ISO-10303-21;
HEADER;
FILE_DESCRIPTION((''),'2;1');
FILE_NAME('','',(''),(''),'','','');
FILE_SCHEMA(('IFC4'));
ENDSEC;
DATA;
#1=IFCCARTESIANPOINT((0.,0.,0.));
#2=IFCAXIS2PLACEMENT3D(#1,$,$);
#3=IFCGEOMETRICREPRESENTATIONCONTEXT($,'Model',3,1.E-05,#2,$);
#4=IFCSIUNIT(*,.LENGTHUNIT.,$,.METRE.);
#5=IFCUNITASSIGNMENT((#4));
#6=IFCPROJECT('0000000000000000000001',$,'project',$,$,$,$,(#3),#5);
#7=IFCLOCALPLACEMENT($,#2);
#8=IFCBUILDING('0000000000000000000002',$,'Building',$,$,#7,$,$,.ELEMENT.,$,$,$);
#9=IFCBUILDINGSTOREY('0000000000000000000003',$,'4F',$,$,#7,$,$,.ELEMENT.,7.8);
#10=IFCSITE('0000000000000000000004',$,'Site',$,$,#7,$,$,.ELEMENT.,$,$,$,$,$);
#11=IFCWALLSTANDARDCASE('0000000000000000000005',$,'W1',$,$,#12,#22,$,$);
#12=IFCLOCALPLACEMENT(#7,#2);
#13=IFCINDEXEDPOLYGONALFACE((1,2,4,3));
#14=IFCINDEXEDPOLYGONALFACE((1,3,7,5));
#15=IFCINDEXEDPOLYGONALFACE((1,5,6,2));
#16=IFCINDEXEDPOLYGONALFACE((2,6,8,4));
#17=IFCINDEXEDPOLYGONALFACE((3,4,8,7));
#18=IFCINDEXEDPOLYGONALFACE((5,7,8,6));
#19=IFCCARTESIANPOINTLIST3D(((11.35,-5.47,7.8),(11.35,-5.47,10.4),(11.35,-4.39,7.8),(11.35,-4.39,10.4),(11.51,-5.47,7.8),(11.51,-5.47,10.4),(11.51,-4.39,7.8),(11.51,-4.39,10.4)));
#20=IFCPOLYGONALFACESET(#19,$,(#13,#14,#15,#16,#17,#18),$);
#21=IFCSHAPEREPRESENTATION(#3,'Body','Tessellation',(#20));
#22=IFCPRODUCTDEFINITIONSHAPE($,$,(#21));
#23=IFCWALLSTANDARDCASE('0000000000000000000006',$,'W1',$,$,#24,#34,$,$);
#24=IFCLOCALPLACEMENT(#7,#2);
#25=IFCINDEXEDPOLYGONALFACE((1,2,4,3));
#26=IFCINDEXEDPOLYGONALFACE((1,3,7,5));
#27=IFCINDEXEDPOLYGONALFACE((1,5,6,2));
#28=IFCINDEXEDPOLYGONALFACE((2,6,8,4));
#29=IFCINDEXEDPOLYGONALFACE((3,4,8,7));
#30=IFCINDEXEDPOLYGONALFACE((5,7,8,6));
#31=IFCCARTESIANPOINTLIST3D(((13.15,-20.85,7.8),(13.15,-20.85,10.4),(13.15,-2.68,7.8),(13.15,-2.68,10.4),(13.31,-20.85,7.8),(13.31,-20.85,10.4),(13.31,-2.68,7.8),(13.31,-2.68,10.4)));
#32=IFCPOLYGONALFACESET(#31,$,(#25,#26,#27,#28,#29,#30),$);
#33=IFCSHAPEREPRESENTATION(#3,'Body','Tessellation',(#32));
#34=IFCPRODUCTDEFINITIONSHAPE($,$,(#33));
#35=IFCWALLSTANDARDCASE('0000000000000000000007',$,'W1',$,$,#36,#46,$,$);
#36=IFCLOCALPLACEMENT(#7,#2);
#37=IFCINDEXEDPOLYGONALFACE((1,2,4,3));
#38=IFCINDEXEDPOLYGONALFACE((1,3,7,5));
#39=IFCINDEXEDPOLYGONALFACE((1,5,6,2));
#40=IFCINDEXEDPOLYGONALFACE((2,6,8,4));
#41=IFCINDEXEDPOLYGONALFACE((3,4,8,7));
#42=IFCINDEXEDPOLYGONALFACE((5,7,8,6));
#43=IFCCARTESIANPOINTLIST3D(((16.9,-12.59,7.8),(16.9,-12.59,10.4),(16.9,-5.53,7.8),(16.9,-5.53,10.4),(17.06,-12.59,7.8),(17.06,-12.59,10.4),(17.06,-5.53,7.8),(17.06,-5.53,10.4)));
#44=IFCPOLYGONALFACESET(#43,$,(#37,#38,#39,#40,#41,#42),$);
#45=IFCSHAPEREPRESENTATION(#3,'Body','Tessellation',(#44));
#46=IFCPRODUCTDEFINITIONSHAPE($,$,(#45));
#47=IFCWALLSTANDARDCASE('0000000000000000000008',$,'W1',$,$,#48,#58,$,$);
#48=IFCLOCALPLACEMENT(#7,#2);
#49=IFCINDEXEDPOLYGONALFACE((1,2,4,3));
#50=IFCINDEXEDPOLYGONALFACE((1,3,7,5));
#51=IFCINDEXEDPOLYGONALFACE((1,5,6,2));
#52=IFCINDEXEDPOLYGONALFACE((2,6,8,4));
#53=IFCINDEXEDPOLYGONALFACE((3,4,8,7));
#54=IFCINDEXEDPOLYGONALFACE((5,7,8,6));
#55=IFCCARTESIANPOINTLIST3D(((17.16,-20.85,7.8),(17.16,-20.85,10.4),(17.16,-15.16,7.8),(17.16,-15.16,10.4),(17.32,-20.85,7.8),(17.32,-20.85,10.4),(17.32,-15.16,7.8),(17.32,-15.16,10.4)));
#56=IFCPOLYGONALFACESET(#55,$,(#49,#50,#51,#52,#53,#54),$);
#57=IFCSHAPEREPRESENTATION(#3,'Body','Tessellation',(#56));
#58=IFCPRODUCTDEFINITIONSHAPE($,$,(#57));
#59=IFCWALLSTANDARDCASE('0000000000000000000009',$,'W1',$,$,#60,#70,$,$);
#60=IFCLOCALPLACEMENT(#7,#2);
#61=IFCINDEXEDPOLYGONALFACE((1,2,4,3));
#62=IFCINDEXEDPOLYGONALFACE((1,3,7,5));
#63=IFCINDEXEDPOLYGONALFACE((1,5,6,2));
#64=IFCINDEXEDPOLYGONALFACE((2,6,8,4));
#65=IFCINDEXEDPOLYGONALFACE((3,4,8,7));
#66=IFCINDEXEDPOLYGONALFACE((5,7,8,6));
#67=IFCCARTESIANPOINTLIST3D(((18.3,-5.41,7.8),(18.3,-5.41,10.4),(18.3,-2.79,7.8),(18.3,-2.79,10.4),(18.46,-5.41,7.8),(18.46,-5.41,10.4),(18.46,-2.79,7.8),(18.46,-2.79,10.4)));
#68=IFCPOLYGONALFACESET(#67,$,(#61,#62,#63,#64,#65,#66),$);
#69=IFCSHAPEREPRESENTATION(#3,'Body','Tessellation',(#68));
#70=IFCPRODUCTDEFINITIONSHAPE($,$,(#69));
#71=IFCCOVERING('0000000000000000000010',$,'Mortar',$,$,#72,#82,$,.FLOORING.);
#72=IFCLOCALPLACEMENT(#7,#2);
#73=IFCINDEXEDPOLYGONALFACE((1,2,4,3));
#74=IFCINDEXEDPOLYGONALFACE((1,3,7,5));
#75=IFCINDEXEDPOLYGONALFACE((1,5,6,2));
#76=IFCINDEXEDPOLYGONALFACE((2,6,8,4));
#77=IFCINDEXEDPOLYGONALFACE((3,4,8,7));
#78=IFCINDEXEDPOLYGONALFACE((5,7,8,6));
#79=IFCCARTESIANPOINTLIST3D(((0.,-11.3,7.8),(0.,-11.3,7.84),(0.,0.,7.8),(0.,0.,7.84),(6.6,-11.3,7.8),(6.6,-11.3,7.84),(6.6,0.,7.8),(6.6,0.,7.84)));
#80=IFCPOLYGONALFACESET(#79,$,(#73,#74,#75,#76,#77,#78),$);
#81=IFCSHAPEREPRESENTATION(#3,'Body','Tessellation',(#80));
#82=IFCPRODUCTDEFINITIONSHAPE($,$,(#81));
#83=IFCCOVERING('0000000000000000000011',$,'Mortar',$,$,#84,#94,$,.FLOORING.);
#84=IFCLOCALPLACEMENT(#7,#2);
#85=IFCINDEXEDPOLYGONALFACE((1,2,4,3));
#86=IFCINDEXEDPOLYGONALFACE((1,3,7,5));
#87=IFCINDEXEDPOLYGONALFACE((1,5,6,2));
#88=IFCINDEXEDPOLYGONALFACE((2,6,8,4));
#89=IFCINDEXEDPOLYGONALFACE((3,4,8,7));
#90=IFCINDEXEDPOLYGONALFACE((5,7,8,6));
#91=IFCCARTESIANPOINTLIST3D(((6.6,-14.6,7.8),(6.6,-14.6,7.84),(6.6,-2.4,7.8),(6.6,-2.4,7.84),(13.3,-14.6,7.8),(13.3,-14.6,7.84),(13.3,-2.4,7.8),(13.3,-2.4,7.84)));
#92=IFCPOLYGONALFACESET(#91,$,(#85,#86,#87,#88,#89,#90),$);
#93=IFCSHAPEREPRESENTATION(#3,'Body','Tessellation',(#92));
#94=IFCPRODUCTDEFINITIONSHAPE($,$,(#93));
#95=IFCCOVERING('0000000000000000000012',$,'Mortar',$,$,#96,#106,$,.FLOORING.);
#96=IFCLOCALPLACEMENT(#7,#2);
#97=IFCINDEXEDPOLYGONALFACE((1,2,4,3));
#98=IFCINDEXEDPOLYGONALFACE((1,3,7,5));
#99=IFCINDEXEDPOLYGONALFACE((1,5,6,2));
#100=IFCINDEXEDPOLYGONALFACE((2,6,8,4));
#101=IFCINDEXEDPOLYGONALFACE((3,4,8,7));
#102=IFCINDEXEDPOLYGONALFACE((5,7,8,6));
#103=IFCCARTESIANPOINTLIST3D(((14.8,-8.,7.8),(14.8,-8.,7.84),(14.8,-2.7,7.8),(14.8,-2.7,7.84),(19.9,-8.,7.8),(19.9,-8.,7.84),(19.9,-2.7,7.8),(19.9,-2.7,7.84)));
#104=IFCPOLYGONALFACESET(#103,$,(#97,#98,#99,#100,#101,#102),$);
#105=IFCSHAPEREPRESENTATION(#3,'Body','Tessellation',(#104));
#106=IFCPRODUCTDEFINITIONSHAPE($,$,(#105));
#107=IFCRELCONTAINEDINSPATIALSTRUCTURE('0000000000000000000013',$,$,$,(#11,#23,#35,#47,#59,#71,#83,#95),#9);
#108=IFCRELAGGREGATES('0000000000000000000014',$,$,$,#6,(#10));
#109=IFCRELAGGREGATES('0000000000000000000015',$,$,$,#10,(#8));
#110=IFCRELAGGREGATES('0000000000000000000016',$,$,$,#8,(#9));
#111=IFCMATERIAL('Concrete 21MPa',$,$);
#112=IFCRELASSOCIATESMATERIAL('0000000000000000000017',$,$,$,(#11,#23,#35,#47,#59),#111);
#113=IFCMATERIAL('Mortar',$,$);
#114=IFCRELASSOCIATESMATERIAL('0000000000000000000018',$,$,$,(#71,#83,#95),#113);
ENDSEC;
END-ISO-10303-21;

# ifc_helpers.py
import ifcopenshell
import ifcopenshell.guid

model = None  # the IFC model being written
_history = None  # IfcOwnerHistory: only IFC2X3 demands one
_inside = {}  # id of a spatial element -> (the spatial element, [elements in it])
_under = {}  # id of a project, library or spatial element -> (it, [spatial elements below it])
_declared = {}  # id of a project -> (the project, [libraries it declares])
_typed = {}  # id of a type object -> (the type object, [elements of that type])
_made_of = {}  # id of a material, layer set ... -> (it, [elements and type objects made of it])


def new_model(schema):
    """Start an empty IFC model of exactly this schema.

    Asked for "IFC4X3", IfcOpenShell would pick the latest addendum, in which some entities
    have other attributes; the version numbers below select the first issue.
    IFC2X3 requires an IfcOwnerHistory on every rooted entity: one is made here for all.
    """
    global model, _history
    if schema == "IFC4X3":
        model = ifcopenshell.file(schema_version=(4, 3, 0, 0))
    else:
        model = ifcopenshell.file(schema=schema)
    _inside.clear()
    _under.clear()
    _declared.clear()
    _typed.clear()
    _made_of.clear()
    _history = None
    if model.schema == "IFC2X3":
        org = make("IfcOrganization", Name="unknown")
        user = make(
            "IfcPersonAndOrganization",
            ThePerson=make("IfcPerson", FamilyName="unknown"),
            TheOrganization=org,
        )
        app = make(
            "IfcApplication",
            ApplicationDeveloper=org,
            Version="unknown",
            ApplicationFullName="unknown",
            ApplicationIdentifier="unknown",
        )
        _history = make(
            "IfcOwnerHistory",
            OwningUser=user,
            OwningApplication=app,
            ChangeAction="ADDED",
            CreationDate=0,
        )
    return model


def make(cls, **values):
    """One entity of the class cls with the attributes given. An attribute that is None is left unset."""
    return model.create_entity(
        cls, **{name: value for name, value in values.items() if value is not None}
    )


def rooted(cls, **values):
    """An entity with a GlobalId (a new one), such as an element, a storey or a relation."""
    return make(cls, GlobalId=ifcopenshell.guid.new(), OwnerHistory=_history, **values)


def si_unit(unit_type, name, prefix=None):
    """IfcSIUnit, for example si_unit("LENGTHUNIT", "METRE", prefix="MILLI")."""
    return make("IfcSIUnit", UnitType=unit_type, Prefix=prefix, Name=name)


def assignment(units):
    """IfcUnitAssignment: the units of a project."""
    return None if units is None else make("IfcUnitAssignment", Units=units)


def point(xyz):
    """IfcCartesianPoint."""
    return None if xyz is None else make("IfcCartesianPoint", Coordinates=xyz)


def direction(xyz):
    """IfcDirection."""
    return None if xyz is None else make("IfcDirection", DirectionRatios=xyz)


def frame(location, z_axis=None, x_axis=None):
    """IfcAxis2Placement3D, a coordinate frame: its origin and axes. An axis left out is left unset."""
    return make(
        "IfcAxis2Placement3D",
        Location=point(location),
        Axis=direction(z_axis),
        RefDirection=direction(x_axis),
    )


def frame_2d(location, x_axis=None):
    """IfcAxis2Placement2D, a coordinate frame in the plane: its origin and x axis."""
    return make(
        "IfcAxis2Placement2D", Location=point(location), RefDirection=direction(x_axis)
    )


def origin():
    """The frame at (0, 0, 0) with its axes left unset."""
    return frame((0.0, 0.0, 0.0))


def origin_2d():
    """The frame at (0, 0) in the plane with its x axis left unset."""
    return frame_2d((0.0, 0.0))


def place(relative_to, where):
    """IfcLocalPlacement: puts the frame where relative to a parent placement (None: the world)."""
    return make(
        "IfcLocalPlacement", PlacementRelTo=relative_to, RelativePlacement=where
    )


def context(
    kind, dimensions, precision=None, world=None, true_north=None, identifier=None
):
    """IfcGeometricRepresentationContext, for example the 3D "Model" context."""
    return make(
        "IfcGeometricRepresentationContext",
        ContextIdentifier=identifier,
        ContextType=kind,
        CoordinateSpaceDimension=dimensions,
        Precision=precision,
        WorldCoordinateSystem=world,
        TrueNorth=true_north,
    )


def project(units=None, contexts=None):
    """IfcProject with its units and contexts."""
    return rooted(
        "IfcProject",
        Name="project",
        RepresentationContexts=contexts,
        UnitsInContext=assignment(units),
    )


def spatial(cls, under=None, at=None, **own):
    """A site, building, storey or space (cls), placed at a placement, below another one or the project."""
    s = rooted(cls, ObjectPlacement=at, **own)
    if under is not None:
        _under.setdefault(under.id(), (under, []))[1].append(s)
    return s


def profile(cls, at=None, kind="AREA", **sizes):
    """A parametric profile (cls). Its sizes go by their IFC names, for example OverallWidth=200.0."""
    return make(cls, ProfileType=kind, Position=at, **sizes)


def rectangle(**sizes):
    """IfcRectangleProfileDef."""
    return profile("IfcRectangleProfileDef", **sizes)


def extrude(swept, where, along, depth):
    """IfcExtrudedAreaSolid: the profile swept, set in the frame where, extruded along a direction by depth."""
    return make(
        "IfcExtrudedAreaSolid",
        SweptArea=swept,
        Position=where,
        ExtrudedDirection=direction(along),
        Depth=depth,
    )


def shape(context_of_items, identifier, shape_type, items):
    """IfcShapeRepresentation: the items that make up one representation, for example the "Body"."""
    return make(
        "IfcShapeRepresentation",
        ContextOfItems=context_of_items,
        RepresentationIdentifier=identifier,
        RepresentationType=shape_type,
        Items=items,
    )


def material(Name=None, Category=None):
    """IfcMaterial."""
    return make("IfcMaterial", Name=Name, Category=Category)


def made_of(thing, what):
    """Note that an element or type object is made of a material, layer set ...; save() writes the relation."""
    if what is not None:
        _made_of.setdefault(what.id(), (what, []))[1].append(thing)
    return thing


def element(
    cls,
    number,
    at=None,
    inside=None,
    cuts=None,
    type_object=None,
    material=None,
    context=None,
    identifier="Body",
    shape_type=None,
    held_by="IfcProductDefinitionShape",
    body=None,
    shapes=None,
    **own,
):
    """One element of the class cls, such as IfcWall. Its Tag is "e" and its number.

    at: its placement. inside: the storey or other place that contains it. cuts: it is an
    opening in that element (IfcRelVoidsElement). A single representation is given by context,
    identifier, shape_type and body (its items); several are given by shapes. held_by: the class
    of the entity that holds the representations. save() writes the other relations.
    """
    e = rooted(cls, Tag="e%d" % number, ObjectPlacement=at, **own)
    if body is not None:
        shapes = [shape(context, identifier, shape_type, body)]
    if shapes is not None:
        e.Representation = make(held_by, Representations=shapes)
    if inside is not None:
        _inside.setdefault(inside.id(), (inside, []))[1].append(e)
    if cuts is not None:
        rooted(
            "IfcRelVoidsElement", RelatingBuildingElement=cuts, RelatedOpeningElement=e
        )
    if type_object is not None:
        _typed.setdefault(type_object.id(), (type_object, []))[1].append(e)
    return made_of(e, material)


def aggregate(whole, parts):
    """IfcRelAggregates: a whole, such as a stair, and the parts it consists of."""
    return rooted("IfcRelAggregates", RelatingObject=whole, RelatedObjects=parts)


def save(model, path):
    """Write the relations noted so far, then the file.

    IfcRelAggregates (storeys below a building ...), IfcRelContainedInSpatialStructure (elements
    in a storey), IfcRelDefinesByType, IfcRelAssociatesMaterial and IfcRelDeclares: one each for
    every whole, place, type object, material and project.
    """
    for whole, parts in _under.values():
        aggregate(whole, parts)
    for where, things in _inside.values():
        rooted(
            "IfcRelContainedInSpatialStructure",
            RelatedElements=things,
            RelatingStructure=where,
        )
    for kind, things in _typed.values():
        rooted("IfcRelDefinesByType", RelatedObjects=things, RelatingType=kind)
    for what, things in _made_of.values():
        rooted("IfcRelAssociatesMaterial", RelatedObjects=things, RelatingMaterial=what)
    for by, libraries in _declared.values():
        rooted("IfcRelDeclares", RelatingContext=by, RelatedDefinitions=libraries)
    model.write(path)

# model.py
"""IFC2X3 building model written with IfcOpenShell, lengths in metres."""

from ifc_helpers import new_model, si_unit, frame, origin, origin_2d, place, context, project, spatial, rectangle, extrude, material, element, save


model = new_model("IFC2X3")

# Units and contexts
model_context = context("Model", 3, precision=1e-05, world=origin())
ifc_project = project(units=[si_unit("LENGTHUNIT", "METRE")], contexts=[model_context])

# Site, building, storey
placement = place(None, origin())
site = spatial("IfcSite", under=ifc_project, at=placement, Name="Site", CompositionType="ELEMENT")
building = spatial("IfcBuilding", under=site, at=placement, Name="Building", CompositionType="ELEMENT")
storey = spatial("IfcBuildingStorey", under=building, at=placement, Name="4F", CompositionType="ELEMENT", Elevation=7.8)

# Shared definitions
ifc_material_1 = material(Name="Concrete 21MPa")

# Walls
wall_1_placement = place(None, frame((11.43, -4.93, 7.8)))
element("IfcWallStandardCase", 1, at=wall_1_placement, inside=storey, material=ifc_material_1, Name="W1", context=model_context, shape_type="SweptSolid", body=[
    extrude(rectangle(XDim=0.16, YDim=1.08, at=origin_2d()), origin(), (0.0, 0.0, 1.0), 2.6),
])
wall_2_placement = place(None, frame((13.23, -11.765, 7.8)))
element("IfcWallStandardCase", 2, at=wall_2_placement, inside=storey, material=ifc_material_1, Name="W1", context=model_context, shape_type="SweptSolid", body=[
    extrude(rectangle(XDim=0.16, YDim=18.17, at=origin_2d()), origin(), (0.0, 0.0, 1.0), 2.6),
])
wall_3_placement = place(None, frame((16.98, -9.06, 7.8)))
element("IfcWallStandardCase", 3, at=wall_3_placement, inside=storey, material=ifc_material_1, Name="W1", context=model_context, shape_type="SweptSolid", body=[
    extrude(rectangle(XDim=0.16, YDim=7.06, at=origin_2d()), origin(), (0.0, 0.0, 1.0), 2.6),
])
wall_4_placement = place(None, frame((17.24, -18.005, 7.8)))
element("IfcWallStandardCase", 4, at=wall_4_placement, inside=storey, material=ifc_material_1, Name="W1", context=model_context, shape_type="SweptSolid", body=[
    extrude(rectangle(XDim=0.16, YDim=5.69, at=origin_2d()), origin(), (0.0, 0.0, 1.0), 2.6),
])
wall_5_placement = place(None, frame((18.38, -4.1, 7.8)))
element("IfcWallStandardCase", 5, at=wall_5_placement, inside=storey, material=ifc_material_1, Name="W1", context=model_context, shape_type="SweptSolid", body=[
    extrude(rectangle(XDim=0.16, YDim=2.62, at=origin_2d()), origin(), (0.0, 0.0, 1.0), 2.6),
])

# Coverings
ifc_material_2 = material(Name="Mortar")
covering_1_placement = place(None, frame((3.3, -5.65, 7.8)))
element("IfcCovering", 6, at=covering_1_placement, inside=storey, material=ifc_material_2, Name="Mortar", PredefinedType="FLOORING", context=model_context, shape_type="SweptSolid", body=[
    extrude(rectangle(XDim=6.6, YDim=11.3, at=origin_2d()), origin(), (0.0, 0.0, 1.0), 0.04),
])
covering_2_placement = place(None, frame((9.95, -8.5, 7.8)))
element("IfcCovering", 7, at=covering_2_placement, inside=storey, material=ifc_material_2, Name="Mortar", PredefinedType="FLOORING", context=model_context, shape_type="SweptSolid", body=[
    extrude(rectangle(XDim=6.7, YDim=12.2, at=origin_2d()), origin(), (0.0, 0.0, 1.0), 0.04),
])
covering_3_placement = place(None, frame((17.35, -5.35, 7.8)))
element("IfcCovering", 8, at=covering_3_placement, inside=storey, material=ifc_material_2, Name="Mortar", PredefinedType="FLOORING", context=model_context, shape_type="SweptSolid", body=[
    extrude(rectangle(XDim=5.1, YDim=5.3, at=origin_2d()), origin(), (0.0, 0.0, 1.0), 0.04),
])

save(model, "model.ifc")
